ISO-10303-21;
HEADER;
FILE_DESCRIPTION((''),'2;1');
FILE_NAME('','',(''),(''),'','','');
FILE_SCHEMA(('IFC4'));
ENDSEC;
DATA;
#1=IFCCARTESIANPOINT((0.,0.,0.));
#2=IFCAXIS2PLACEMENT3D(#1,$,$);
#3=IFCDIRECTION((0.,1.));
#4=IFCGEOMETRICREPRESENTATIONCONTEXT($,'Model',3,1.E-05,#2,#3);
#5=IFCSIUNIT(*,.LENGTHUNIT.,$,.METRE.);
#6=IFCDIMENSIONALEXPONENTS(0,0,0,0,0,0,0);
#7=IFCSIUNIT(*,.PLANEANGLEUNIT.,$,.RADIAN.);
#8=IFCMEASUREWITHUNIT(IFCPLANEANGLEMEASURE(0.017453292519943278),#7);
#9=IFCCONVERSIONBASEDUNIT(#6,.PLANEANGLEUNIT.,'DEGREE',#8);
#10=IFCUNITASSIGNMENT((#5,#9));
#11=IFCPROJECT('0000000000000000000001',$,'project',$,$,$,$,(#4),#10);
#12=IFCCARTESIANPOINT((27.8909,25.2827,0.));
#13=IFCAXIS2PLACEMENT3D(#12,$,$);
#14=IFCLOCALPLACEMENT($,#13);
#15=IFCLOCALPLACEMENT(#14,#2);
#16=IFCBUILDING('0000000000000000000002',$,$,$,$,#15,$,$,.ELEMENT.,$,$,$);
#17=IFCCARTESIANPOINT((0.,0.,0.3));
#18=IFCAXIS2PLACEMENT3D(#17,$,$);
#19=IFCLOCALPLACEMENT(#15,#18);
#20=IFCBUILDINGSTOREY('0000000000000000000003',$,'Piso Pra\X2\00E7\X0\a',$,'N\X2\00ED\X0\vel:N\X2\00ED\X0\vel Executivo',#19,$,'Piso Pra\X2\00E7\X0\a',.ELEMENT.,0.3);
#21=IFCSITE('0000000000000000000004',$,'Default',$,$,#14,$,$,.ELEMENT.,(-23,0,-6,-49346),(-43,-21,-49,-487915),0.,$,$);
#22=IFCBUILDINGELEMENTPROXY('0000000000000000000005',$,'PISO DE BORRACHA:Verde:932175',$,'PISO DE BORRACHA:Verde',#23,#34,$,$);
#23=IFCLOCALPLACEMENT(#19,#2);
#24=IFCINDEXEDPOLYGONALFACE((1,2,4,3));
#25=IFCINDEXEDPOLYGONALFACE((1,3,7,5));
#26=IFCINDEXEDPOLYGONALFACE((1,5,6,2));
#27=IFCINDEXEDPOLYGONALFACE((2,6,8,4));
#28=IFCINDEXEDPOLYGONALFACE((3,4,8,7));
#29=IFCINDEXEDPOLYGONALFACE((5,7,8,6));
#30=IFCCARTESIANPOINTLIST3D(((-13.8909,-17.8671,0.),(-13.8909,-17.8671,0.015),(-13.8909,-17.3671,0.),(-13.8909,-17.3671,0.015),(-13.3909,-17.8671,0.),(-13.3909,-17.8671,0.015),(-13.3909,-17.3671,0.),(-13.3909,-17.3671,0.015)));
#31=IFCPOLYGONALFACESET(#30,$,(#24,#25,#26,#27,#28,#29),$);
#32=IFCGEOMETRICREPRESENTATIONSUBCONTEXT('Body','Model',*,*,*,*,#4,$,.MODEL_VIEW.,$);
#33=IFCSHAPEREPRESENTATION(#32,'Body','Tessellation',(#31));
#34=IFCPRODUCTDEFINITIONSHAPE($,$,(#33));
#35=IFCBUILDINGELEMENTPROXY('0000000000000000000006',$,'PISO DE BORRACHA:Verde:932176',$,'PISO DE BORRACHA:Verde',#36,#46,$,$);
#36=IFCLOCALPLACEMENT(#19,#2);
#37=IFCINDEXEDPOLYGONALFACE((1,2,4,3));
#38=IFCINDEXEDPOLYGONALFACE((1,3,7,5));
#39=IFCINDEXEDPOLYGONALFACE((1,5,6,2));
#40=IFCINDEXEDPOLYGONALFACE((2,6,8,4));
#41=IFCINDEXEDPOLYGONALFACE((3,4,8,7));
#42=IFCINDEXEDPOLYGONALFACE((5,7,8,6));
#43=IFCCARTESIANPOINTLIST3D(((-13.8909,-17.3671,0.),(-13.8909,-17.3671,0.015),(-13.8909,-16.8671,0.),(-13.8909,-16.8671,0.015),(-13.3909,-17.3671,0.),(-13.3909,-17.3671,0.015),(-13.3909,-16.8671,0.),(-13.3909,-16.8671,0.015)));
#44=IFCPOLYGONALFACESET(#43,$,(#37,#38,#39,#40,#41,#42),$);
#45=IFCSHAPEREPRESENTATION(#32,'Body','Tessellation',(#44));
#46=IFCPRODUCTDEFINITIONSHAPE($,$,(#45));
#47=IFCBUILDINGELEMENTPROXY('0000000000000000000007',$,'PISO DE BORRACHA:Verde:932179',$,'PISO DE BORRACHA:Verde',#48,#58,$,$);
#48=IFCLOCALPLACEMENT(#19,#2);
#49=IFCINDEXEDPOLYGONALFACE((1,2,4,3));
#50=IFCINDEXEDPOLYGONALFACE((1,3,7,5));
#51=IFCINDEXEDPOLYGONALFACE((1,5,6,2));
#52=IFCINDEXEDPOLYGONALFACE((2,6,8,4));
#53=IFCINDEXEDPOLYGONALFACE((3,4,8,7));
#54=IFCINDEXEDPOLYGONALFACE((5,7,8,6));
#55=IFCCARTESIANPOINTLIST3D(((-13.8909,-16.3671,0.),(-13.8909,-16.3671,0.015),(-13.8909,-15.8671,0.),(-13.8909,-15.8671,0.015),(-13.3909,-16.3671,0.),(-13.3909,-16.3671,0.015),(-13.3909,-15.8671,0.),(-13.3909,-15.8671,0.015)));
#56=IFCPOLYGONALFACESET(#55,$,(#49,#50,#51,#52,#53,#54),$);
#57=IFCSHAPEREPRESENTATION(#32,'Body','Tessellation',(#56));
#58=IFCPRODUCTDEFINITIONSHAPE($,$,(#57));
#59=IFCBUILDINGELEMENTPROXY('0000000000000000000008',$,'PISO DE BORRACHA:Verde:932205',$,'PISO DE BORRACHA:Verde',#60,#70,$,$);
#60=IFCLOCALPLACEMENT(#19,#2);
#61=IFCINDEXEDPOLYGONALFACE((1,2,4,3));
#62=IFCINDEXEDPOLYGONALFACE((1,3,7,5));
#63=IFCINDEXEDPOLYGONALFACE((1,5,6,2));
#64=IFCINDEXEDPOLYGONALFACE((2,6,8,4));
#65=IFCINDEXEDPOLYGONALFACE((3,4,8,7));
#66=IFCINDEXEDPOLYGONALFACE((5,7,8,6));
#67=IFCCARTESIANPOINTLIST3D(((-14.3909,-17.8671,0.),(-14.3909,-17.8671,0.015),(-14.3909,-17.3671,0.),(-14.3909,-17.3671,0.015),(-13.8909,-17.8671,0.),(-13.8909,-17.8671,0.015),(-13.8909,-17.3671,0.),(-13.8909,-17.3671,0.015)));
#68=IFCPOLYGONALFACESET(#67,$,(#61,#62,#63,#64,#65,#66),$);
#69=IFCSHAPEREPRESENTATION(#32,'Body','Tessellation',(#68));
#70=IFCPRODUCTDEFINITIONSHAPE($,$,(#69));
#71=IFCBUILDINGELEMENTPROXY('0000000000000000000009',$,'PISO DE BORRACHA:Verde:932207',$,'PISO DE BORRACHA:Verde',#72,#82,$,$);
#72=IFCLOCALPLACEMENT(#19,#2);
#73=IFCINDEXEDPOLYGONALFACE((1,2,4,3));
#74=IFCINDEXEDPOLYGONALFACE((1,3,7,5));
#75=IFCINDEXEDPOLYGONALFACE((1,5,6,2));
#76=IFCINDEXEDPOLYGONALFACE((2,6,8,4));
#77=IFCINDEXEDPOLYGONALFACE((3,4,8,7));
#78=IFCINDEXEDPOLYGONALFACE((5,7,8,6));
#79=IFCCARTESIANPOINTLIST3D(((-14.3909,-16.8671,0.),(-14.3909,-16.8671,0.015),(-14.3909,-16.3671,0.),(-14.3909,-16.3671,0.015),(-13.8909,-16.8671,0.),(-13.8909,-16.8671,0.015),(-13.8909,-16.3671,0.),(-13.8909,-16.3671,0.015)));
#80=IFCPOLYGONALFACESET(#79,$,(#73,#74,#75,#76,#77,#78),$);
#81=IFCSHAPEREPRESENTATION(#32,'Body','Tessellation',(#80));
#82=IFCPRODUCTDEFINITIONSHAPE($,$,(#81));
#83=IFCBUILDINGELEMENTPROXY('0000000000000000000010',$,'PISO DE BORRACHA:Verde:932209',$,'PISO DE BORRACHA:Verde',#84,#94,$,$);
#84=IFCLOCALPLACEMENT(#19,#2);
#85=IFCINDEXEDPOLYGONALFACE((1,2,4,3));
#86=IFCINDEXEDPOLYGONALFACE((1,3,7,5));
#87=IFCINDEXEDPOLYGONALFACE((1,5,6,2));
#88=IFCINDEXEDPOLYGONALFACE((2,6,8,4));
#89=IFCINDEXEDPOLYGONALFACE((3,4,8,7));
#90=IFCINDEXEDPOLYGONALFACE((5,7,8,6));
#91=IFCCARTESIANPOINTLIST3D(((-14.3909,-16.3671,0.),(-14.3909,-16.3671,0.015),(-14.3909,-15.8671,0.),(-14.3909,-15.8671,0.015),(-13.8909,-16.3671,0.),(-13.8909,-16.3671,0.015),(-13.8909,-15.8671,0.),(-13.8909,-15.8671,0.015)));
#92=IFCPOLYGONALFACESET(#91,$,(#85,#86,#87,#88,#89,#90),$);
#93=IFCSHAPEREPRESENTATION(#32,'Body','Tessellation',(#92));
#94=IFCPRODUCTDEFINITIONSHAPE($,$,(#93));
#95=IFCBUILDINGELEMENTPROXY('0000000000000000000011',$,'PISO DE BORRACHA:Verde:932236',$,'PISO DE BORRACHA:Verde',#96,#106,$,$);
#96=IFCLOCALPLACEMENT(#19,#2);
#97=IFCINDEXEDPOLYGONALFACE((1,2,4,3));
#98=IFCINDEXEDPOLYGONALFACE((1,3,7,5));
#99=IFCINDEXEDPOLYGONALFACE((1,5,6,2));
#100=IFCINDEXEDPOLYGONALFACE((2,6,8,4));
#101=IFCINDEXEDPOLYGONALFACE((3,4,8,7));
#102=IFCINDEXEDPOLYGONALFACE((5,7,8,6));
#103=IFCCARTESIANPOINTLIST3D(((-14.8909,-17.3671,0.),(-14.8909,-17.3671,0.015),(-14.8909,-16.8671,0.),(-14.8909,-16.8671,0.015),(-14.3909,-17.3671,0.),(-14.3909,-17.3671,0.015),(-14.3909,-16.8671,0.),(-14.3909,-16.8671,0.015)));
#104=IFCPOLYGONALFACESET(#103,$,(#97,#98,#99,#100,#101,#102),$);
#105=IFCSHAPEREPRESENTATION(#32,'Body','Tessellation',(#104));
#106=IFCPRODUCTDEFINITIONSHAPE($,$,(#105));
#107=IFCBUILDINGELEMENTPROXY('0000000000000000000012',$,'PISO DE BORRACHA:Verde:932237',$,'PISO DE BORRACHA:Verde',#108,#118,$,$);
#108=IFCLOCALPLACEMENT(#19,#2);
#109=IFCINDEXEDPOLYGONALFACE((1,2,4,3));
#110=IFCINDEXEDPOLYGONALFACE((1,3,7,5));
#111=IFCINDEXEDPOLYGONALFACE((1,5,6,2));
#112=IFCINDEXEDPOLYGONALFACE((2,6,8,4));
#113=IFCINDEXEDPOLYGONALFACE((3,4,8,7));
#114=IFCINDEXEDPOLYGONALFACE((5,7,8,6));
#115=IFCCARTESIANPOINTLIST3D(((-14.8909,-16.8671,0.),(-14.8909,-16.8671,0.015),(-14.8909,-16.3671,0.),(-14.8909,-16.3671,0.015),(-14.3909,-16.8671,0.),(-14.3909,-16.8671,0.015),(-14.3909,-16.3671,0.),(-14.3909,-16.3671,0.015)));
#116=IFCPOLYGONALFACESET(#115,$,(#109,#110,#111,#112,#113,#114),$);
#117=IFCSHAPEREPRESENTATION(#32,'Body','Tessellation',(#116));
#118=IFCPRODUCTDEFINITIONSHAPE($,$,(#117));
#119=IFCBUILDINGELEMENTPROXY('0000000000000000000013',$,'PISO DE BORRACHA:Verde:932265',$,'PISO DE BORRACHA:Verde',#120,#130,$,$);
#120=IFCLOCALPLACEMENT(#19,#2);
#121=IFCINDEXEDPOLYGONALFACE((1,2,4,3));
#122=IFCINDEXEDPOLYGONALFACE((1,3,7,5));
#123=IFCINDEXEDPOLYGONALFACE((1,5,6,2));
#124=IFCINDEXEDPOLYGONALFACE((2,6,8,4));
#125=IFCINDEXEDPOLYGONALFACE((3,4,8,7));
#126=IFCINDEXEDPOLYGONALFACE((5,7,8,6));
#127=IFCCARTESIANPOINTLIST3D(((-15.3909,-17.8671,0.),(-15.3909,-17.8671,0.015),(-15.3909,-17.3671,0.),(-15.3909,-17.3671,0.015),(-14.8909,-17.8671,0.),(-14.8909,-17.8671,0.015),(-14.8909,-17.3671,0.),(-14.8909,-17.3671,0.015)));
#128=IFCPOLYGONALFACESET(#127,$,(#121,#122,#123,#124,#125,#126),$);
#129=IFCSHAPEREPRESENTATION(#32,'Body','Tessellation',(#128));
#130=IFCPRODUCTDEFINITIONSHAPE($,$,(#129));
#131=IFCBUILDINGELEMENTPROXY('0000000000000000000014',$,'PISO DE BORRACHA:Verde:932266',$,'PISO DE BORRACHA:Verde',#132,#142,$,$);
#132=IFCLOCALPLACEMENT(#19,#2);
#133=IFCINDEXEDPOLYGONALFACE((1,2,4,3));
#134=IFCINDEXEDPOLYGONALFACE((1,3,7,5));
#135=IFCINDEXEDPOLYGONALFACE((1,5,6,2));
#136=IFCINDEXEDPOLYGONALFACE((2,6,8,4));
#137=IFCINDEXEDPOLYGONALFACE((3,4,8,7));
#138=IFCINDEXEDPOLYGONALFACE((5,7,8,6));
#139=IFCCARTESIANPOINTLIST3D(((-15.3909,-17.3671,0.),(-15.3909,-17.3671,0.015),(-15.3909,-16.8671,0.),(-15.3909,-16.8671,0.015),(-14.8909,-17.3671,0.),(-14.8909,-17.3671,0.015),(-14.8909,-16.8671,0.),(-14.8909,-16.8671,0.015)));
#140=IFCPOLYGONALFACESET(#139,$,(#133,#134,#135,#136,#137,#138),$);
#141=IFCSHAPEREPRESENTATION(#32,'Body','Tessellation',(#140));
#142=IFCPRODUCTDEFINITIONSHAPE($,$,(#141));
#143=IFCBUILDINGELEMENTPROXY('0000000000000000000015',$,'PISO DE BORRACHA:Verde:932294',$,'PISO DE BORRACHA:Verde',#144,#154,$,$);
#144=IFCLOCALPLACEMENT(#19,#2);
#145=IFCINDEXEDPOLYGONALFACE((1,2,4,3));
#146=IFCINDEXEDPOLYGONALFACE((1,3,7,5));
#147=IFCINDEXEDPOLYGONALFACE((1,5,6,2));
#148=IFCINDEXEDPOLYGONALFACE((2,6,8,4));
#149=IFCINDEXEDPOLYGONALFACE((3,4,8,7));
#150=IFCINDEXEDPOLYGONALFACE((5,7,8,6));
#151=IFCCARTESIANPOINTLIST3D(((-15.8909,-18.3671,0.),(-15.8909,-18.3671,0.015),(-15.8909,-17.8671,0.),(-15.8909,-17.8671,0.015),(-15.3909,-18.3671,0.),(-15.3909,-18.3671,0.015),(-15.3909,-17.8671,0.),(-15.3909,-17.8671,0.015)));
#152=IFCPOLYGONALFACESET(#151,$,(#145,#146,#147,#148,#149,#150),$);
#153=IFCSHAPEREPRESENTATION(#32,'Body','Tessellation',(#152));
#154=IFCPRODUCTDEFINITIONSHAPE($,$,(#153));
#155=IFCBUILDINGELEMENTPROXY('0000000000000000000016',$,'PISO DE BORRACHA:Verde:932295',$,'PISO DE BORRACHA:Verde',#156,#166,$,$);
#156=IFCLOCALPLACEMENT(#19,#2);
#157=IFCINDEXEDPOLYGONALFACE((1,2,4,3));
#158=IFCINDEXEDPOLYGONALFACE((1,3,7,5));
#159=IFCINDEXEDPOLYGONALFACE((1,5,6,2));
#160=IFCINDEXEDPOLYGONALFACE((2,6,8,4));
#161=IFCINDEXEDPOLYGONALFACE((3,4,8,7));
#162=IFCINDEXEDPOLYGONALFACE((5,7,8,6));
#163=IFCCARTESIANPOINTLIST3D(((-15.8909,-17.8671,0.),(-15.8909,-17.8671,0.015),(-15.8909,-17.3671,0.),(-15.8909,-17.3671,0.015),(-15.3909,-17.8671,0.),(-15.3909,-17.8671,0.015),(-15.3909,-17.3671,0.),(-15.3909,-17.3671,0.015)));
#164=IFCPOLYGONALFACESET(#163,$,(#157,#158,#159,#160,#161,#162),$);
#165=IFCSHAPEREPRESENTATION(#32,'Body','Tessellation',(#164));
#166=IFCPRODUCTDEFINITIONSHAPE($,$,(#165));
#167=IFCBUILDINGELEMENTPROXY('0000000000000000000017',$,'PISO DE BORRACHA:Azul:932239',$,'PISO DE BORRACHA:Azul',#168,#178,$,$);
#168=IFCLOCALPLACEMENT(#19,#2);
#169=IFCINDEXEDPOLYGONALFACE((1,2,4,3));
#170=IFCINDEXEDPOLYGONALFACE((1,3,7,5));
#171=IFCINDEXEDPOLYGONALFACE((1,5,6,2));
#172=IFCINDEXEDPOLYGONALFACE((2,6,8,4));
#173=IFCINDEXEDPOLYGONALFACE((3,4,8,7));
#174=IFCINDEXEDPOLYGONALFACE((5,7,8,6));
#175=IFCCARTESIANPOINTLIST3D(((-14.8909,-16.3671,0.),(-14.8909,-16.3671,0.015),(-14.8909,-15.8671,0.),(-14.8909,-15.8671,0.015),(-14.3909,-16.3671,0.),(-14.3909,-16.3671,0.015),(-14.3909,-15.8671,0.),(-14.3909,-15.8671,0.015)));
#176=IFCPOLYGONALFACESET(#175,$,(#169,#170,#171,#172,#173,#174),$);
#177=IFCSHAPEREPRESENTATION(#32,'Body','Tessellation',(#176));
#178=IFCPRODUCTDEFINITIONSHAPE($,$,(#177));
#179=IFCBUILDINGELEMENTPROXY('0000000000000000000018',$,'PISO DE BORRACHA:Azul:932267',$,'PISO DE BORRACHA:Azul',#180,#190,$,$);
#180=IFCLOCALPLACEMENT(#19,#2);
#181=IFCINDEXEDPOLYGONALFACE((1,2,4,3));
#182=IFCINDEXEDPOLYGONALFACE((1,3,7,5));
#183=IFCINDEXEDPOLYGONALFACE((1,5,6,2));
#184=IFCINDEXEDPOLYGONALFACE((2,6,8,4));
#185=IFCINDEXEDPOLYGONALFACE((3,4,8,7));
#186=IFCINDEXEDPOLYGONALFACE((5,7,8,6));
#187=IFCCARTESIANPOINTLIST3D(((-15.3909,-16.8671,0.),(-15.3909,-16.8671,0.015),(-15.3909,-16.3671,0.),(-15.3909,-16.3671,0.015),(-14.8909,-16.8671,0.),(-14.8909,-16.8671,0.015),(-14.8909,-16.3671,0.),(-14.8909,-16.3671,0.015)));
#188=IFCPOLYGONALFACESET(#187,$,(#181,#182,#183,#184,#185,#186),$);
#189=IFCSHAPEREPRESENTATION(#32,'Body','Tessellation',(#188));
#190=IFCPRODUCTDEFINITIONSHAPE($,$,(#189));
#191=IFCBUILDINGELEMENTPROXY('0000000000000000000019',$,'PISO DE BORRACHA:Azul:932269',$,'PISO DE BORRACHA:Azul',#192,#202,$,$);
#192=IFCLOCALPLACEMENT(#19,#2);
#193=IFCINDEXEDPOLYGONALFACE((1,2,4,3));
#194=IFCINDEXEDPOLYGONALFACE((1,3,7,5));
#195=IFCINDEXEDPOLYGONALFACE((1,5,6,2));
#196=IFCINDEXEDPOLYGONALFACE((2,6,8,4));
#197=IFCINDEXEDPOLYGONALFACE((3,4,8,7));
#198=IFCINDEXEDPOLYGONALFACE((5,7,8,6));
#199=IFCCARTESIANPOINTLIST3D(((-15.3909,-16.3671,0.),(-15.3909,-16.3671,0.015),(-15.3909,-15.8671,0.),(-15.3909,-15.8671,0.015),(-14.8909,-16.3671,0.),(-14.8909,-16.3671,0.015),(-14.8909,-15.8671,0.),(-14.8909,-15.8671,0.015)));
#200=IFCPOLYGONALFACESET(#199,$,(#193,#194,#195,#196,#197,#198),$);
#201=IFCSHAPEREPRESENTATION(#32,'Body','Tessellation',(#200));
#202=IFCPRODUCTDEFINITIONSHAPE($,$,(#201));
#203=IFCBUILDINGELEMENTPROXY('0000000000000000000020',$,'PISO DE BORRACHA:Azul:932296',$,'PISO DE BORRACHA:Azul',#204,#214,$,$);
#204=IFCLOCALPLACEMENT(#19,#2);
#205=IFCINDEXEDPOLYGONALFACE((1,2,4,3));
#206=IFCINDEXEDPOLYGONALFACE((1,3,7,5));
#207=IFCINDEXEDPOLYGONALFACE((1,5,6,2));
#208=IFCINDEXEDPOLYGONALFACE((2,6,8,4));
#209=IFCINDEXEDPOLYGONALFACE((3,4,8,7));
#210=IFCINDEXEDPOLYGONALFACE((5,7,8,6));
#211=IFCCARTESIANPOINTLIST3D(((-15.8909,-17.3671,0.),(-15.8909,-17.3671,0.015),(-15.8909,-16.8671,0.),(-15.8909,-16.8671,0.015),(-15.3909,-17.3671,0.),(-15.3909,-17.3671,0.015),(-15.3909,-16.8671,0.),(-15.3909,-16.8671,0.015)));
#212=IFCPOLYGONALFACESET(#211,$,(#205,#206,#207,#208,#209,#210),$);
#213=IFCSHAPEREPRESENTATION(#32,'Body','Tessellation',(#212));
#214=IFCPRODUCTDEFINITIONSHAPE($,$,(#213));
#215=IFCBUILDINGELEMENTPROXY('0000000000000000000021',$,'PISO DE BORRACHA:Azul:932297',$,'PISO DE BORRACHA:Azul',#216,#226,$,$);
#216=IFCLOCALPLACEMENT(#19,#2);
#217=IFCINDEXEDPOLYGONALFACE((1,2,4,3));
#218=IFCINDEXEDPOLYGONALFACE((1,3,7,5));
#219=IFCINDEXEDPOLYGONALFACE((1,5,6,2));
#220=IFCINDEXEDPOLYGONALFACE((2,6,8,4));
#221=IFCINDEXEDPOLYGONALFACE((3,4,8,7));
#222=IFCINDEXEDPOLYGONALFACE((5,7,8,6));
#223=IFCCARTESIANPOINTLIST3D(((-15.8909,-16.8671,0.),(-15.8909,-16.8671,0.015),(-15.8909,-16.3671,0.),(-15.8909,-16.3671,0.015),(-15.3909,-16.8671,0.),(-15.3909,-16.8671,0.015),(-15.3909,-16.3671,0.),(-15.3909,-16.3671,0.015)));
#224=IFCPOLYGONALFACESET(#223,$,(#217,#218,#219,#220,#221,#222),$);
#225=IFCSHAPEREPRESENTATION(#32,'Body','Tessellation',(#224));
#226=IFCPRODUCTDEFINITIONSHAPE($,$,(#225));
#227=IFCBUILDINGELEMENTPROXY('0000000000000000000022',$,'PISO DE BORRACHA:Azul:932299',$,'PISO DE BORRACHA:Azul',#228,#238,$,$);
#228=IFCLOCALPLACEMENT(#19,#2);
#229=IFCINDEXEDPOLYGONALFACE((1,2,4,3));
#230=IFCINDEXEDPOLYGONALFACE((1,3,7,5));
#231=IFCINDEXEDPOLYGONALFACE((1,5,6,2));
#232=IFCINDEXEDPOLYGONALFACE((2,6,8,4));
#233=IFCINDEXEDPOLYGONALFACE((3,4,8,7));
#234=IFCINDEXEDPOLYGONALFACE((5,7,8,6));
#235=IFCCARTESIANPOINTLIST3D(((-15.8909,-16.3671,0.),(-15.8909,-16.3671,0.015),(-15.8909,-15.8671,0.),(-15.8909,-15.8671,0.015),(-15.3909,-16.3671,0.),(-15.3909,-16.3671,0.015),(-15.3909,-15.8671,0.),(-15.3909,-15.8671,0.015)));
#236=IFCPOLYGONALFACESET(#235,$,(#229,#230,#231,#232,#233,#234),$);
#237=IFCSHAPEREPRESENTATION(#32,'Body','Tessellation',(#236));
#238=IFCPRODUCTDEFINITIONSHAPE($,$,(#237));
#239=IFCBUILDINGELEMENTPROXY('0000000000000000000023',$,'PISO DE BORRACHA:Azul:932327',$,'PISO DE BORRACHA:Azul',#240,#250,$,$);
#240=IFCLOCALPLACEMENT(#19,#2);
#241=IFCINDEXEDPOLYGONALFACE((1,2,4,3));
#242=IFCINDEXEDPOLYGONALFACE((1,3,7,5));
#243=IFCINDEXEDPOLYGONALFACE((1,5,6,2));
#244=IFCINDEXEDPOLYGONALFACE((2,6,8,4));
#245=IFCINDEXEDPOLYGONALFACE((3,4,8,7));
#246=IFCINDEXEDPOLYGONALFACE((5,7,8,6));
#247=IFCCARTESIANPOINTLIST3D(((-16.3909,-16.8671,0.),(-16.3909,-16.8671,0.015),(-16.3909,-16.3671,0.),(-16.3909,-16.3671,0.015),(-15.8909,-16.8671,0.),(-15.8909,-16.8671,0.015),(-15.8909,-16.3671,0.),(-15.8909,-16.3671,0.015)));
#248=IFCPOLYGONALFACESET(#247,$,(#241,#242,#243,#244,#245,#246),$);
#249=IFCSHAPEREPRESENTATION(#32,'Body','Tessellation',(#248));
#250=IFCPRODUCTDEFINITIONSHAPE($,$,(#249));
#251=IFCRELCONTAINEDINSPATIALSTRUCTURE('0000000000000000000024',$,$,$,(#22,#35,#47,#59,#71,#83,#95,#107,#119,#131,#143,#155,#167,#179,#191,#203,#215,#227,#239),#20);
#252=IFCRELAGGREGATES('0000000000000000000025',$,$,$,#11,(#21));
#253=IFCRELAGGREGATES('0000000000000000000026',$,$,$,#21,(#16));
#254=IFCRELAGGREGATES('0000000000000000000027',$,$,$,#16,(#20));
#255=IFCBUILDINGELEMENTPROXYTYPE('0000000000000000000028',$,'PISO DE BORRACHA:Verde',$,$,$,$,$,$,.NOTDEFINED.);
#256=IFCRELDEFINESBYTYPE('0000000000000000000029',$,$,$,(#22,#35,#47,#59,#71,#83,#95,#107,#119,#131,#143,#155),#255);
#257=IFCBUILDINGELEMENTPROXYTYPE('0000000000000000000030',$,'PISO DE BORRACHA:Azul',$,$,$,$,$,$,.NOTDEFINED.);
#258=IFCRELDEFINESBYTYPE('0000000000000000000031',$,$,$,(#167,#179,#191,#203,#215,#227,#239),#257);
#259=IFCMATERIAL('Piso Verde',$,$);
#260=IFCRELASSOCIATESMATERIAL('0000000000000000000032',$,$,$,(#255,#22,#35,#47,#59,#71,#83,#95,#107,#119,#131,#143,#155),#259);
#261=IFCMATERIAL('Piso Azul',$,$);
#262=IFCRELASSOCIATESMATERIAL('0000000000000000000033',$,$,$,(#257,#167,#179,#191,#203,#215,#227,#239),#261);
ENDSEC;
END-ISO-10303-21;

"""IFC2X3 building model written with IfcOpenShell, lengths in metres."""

from ifc_helpers import new_model, entity, si_unit, converted_unit, direction, frame, origin, origin_2d_with_axis, place, context, subcontext, project, spatial, rectangle, extrude, source, transform, mapped, material, type_object, type_shapes, element, save


model = new_model("IFC2X3")

# Units and contexts
model_context = context("Model", 3, precision=1e-05, world=origin(), true_north=direction((0.0, 1.0)))
body_context = subcontext(model_context, "Body", "Model", "MODEL_VIEW")
ifc_project = project(units=[si_unit("LENGTHUNIT", "METRE"), converted_unit("PLANEANGLEUNIT", "DEGREE", entity("IfcPlaneAngleMeasure", 0.017453292519943278), si_unit("PLANEANGLEUNIT", "RADIAN"), dimensions=[0, 0, 0, 0, 0, 0, 0])], contexts=[model_context])

# Site, building, storey
site_placement = place(None, frame((27.8909, 25.2827, 0.0)))
site = spatial("IfcSite", under=ifc_project, at=site_placement, Name="Default", CompositionType="ELEMENT", RefLatitude=(-23, 0, -6, -49346), RefLongitude=(-43, -21, -49, -487915), RefElevation=0.0)
building_placement = place(site_placement, origin())
building = spatial("IfcBuilding", under=site, at=building_placement, CompositionType="ELEMENT")
storey_placement = place(building_placement, frame((0.0, 0.0, 0.3)))
storey = spatial("IfcBuildingStorey", under=building, at=storey_placement, Name="Piso Praça", ObjectType="Nível:Nível Executivo", LongName="Piso Praça", CompositionType="ELEMENT", Elevation=0.3)

# Building element proxies
ifc_material_1 = material(Name="Piso Verde")
building_element_proxy_type_1 = type_object("IfcBuildingElementProxyType", Name="PISO DE BORRACHA:Verde", PredefinedType="NOTDEFINED", material=ifc_material_1)
shared_shape_1 = source(origin(), body_context, "Body", "SweptSolid", [
    extrude(rectangle(XDim=0.5, YDim=0.5, at=origin_2d_with_axis()), frame((0.25, 0.25, 0.0), z_axis=(0.0, 0.0, 1.0), x_axis=(-1.0, 0.0, 0.0)), (0.0, 0.0, 1.0), 0.015),
])
type_shapes(building_element_proxy_type_1, [shared_shape_1])
for number, where, z_axis, x_axis, name in (
    (1, (-13.8909, -17.3671, 0.0), (0.0, 0.0, 1.0), (0.0, -1.0, 0.0), "PISO DE BORRACHA:Verde:932175"),
    (2, (-13.8909, -16.8671, 0.0), (0.0, 0.0, 1.0), (0.0, -1.0, 0.0), "PISO DE BORRACHA:Verde:932176"),
    (3, (-13.8909, -15.8671, 0.0), (0.0, 0.0, 1.0), (0.0, -1.0, 0.0), "PISO DE BORRACHA:Verde:932179"),
    (4, (-14.3909, -17.3671, 0.0), (0.0, 0.0, 1.0), (0.0, -1.0, 0.0), "PISO DE BORRACHA:Verde:932205"),
    (5, (-14.3909, -16.3671, 0.0), (0.0, 0.0, 1.0), (0.0, -1.0, 0.0), "PISO DE BORRACHA:Verde:932207"),
    (6, (-14.3909, -15.8671, 0.0), (0.0, 0.0, 1.0), (0.0, -1.0, 0.0), "PISO DE BORRACHA:Verde:932209"),
    (7, (-14.8909, -16.8671, 0.0), (0.0, 0.0, 1.0), (0.0, -1.0, 0.0), "PISO DE BORRACHA:Verde:932236"),
    (8, (-14.8909, -16.3671, 0.0), (0.0, 0.0, 1.0), (0.0, -1.0, 0.0), "PISO DE BORRACHA:Verde:932237"),
    (9, (-15.3909, -17.3671, 0.0), (0.0, 0.0, 1.0), (0.0, -1.0, 0.0), "PISO DE BORRACHA:Verde:932265"),
    (10, (-15.3909, -16.8671, 0.0), (0.0, 0.0, 1.0), (0.0, -1.0, 0.0), "PISO DE BORRACHA:Verde:932266"),
    (11, (-15.8909, -17.8671, 0.0), (0.0, 0.0, 1.0), (0.0, -1.0, 0.0), "PISO DE BORRACHA:Verde:932294"),
    (12, (-15.8909, -17.3671, 0.0), (0.0, 0.0, 1.0), (0.0, -1.0, 0.0), "PISO DE BORRACHA:Verde:932295"),
):
    element("IfcBuildingElementProxy", number, at=place(storey_placement, frame(where, z_axis=z_axis, x_axis=x_axis)), inside=storey, type_object=building_element_proxy_type_1, material=ifc_material_1, Name=name, ObjectType="PISO DE BORRACHA:Verde", context=body_context, shape_type="MappedRepresentation", body=[
        mapped(shared_shape_1, transform((0.0, 0.0, 0.0), scale=1.0)),
    ])
ifc_material_2 = material(Name="Piso Azul")
building_element_proxy_type_2 = type_object("IfcBuildingElementProxyType", Name="PISO DE BORRACHA:Azul", PredefinedType="NOTDEFINED", material=ifc_material_2)
shared_shape_2 = source(origin(), body_context, "Body", "SweptSolid", [
    extrude(rectangle(XDim=0.5, YDim=0.5, at=origin_2d_with_axis()), frame((0.25, 0.25, 0.0), z_axis=(0.0, 0.0, 1.0), x_axis=(-1.0, 0.0, 0.0)), (0.0, 0.0, 1.0), 0.015),
])
type_shapes(building_element_proxy_type_2, [shared_shape_2])
for number, where, z_axis, x_axis, name in (
    (13, (-14.8909, -15.8671, 0.0), (0.0, 0.0, 1.0), (0.0, -1.0, 0.0), "PISO DE BORRACHA:Azul:932239"),
    (14, (-15.3909, -16.3671, 0.0), (0.0, 0.0, 1.0), (0.0, -1.0, 0.0), "PISO DE BORRACHA:Azul:932267"),
    (15, (-15.3909, -15.8671, 0.0), (0.0, 0.0, 1.0), (0.0, -1.0, 0.0), "PISO DE BORRACHA:Azul:932269"),
    (16, (-15.8909, -16.8671, 0.0), (0.0, 0.0, 1.0), (0.0, -1.0, 0.0), "PISO DE BORRACHA:Azul:932296"),
    (17, (-15.8909, -16.3671, 0.0), (0.0, 0.0, 1.0), (0.0, -1.0, 0.0), "PISO DE BORRACHA:Azul:932297"),
    (18, (-15.8909, -15.8671, 0.0), (0.0, 0.0, 1.0), (0.0, -1.0, 0.0), "PISO DE BORRACHA:Azul:932299"),
    (19, (-16.3909, -16.3671, 0.0), (0.0, 0.0, 1.0), (0.0, -1.0, 0.0), "PISO DE BORRACHA:Azul:932327"),
):
    element("IfcBuildingElementProxy", number, at=place(storey_placement, frame(where, z_axis=z_axis, x_axis=x_axis)), inside=storey, type_object=building_element_proxy_type_2, material=ifc_material_2, Name=name, ObjectType="PISO DE BORRACHA:Azul", context=body_context, shape_type="MappedRepresentation", body=[
        mapped(shared_shape_2, transform((0.0, 0.0, 0.0), scale=1.0)),
    ])

save(model, "model.ifc")
